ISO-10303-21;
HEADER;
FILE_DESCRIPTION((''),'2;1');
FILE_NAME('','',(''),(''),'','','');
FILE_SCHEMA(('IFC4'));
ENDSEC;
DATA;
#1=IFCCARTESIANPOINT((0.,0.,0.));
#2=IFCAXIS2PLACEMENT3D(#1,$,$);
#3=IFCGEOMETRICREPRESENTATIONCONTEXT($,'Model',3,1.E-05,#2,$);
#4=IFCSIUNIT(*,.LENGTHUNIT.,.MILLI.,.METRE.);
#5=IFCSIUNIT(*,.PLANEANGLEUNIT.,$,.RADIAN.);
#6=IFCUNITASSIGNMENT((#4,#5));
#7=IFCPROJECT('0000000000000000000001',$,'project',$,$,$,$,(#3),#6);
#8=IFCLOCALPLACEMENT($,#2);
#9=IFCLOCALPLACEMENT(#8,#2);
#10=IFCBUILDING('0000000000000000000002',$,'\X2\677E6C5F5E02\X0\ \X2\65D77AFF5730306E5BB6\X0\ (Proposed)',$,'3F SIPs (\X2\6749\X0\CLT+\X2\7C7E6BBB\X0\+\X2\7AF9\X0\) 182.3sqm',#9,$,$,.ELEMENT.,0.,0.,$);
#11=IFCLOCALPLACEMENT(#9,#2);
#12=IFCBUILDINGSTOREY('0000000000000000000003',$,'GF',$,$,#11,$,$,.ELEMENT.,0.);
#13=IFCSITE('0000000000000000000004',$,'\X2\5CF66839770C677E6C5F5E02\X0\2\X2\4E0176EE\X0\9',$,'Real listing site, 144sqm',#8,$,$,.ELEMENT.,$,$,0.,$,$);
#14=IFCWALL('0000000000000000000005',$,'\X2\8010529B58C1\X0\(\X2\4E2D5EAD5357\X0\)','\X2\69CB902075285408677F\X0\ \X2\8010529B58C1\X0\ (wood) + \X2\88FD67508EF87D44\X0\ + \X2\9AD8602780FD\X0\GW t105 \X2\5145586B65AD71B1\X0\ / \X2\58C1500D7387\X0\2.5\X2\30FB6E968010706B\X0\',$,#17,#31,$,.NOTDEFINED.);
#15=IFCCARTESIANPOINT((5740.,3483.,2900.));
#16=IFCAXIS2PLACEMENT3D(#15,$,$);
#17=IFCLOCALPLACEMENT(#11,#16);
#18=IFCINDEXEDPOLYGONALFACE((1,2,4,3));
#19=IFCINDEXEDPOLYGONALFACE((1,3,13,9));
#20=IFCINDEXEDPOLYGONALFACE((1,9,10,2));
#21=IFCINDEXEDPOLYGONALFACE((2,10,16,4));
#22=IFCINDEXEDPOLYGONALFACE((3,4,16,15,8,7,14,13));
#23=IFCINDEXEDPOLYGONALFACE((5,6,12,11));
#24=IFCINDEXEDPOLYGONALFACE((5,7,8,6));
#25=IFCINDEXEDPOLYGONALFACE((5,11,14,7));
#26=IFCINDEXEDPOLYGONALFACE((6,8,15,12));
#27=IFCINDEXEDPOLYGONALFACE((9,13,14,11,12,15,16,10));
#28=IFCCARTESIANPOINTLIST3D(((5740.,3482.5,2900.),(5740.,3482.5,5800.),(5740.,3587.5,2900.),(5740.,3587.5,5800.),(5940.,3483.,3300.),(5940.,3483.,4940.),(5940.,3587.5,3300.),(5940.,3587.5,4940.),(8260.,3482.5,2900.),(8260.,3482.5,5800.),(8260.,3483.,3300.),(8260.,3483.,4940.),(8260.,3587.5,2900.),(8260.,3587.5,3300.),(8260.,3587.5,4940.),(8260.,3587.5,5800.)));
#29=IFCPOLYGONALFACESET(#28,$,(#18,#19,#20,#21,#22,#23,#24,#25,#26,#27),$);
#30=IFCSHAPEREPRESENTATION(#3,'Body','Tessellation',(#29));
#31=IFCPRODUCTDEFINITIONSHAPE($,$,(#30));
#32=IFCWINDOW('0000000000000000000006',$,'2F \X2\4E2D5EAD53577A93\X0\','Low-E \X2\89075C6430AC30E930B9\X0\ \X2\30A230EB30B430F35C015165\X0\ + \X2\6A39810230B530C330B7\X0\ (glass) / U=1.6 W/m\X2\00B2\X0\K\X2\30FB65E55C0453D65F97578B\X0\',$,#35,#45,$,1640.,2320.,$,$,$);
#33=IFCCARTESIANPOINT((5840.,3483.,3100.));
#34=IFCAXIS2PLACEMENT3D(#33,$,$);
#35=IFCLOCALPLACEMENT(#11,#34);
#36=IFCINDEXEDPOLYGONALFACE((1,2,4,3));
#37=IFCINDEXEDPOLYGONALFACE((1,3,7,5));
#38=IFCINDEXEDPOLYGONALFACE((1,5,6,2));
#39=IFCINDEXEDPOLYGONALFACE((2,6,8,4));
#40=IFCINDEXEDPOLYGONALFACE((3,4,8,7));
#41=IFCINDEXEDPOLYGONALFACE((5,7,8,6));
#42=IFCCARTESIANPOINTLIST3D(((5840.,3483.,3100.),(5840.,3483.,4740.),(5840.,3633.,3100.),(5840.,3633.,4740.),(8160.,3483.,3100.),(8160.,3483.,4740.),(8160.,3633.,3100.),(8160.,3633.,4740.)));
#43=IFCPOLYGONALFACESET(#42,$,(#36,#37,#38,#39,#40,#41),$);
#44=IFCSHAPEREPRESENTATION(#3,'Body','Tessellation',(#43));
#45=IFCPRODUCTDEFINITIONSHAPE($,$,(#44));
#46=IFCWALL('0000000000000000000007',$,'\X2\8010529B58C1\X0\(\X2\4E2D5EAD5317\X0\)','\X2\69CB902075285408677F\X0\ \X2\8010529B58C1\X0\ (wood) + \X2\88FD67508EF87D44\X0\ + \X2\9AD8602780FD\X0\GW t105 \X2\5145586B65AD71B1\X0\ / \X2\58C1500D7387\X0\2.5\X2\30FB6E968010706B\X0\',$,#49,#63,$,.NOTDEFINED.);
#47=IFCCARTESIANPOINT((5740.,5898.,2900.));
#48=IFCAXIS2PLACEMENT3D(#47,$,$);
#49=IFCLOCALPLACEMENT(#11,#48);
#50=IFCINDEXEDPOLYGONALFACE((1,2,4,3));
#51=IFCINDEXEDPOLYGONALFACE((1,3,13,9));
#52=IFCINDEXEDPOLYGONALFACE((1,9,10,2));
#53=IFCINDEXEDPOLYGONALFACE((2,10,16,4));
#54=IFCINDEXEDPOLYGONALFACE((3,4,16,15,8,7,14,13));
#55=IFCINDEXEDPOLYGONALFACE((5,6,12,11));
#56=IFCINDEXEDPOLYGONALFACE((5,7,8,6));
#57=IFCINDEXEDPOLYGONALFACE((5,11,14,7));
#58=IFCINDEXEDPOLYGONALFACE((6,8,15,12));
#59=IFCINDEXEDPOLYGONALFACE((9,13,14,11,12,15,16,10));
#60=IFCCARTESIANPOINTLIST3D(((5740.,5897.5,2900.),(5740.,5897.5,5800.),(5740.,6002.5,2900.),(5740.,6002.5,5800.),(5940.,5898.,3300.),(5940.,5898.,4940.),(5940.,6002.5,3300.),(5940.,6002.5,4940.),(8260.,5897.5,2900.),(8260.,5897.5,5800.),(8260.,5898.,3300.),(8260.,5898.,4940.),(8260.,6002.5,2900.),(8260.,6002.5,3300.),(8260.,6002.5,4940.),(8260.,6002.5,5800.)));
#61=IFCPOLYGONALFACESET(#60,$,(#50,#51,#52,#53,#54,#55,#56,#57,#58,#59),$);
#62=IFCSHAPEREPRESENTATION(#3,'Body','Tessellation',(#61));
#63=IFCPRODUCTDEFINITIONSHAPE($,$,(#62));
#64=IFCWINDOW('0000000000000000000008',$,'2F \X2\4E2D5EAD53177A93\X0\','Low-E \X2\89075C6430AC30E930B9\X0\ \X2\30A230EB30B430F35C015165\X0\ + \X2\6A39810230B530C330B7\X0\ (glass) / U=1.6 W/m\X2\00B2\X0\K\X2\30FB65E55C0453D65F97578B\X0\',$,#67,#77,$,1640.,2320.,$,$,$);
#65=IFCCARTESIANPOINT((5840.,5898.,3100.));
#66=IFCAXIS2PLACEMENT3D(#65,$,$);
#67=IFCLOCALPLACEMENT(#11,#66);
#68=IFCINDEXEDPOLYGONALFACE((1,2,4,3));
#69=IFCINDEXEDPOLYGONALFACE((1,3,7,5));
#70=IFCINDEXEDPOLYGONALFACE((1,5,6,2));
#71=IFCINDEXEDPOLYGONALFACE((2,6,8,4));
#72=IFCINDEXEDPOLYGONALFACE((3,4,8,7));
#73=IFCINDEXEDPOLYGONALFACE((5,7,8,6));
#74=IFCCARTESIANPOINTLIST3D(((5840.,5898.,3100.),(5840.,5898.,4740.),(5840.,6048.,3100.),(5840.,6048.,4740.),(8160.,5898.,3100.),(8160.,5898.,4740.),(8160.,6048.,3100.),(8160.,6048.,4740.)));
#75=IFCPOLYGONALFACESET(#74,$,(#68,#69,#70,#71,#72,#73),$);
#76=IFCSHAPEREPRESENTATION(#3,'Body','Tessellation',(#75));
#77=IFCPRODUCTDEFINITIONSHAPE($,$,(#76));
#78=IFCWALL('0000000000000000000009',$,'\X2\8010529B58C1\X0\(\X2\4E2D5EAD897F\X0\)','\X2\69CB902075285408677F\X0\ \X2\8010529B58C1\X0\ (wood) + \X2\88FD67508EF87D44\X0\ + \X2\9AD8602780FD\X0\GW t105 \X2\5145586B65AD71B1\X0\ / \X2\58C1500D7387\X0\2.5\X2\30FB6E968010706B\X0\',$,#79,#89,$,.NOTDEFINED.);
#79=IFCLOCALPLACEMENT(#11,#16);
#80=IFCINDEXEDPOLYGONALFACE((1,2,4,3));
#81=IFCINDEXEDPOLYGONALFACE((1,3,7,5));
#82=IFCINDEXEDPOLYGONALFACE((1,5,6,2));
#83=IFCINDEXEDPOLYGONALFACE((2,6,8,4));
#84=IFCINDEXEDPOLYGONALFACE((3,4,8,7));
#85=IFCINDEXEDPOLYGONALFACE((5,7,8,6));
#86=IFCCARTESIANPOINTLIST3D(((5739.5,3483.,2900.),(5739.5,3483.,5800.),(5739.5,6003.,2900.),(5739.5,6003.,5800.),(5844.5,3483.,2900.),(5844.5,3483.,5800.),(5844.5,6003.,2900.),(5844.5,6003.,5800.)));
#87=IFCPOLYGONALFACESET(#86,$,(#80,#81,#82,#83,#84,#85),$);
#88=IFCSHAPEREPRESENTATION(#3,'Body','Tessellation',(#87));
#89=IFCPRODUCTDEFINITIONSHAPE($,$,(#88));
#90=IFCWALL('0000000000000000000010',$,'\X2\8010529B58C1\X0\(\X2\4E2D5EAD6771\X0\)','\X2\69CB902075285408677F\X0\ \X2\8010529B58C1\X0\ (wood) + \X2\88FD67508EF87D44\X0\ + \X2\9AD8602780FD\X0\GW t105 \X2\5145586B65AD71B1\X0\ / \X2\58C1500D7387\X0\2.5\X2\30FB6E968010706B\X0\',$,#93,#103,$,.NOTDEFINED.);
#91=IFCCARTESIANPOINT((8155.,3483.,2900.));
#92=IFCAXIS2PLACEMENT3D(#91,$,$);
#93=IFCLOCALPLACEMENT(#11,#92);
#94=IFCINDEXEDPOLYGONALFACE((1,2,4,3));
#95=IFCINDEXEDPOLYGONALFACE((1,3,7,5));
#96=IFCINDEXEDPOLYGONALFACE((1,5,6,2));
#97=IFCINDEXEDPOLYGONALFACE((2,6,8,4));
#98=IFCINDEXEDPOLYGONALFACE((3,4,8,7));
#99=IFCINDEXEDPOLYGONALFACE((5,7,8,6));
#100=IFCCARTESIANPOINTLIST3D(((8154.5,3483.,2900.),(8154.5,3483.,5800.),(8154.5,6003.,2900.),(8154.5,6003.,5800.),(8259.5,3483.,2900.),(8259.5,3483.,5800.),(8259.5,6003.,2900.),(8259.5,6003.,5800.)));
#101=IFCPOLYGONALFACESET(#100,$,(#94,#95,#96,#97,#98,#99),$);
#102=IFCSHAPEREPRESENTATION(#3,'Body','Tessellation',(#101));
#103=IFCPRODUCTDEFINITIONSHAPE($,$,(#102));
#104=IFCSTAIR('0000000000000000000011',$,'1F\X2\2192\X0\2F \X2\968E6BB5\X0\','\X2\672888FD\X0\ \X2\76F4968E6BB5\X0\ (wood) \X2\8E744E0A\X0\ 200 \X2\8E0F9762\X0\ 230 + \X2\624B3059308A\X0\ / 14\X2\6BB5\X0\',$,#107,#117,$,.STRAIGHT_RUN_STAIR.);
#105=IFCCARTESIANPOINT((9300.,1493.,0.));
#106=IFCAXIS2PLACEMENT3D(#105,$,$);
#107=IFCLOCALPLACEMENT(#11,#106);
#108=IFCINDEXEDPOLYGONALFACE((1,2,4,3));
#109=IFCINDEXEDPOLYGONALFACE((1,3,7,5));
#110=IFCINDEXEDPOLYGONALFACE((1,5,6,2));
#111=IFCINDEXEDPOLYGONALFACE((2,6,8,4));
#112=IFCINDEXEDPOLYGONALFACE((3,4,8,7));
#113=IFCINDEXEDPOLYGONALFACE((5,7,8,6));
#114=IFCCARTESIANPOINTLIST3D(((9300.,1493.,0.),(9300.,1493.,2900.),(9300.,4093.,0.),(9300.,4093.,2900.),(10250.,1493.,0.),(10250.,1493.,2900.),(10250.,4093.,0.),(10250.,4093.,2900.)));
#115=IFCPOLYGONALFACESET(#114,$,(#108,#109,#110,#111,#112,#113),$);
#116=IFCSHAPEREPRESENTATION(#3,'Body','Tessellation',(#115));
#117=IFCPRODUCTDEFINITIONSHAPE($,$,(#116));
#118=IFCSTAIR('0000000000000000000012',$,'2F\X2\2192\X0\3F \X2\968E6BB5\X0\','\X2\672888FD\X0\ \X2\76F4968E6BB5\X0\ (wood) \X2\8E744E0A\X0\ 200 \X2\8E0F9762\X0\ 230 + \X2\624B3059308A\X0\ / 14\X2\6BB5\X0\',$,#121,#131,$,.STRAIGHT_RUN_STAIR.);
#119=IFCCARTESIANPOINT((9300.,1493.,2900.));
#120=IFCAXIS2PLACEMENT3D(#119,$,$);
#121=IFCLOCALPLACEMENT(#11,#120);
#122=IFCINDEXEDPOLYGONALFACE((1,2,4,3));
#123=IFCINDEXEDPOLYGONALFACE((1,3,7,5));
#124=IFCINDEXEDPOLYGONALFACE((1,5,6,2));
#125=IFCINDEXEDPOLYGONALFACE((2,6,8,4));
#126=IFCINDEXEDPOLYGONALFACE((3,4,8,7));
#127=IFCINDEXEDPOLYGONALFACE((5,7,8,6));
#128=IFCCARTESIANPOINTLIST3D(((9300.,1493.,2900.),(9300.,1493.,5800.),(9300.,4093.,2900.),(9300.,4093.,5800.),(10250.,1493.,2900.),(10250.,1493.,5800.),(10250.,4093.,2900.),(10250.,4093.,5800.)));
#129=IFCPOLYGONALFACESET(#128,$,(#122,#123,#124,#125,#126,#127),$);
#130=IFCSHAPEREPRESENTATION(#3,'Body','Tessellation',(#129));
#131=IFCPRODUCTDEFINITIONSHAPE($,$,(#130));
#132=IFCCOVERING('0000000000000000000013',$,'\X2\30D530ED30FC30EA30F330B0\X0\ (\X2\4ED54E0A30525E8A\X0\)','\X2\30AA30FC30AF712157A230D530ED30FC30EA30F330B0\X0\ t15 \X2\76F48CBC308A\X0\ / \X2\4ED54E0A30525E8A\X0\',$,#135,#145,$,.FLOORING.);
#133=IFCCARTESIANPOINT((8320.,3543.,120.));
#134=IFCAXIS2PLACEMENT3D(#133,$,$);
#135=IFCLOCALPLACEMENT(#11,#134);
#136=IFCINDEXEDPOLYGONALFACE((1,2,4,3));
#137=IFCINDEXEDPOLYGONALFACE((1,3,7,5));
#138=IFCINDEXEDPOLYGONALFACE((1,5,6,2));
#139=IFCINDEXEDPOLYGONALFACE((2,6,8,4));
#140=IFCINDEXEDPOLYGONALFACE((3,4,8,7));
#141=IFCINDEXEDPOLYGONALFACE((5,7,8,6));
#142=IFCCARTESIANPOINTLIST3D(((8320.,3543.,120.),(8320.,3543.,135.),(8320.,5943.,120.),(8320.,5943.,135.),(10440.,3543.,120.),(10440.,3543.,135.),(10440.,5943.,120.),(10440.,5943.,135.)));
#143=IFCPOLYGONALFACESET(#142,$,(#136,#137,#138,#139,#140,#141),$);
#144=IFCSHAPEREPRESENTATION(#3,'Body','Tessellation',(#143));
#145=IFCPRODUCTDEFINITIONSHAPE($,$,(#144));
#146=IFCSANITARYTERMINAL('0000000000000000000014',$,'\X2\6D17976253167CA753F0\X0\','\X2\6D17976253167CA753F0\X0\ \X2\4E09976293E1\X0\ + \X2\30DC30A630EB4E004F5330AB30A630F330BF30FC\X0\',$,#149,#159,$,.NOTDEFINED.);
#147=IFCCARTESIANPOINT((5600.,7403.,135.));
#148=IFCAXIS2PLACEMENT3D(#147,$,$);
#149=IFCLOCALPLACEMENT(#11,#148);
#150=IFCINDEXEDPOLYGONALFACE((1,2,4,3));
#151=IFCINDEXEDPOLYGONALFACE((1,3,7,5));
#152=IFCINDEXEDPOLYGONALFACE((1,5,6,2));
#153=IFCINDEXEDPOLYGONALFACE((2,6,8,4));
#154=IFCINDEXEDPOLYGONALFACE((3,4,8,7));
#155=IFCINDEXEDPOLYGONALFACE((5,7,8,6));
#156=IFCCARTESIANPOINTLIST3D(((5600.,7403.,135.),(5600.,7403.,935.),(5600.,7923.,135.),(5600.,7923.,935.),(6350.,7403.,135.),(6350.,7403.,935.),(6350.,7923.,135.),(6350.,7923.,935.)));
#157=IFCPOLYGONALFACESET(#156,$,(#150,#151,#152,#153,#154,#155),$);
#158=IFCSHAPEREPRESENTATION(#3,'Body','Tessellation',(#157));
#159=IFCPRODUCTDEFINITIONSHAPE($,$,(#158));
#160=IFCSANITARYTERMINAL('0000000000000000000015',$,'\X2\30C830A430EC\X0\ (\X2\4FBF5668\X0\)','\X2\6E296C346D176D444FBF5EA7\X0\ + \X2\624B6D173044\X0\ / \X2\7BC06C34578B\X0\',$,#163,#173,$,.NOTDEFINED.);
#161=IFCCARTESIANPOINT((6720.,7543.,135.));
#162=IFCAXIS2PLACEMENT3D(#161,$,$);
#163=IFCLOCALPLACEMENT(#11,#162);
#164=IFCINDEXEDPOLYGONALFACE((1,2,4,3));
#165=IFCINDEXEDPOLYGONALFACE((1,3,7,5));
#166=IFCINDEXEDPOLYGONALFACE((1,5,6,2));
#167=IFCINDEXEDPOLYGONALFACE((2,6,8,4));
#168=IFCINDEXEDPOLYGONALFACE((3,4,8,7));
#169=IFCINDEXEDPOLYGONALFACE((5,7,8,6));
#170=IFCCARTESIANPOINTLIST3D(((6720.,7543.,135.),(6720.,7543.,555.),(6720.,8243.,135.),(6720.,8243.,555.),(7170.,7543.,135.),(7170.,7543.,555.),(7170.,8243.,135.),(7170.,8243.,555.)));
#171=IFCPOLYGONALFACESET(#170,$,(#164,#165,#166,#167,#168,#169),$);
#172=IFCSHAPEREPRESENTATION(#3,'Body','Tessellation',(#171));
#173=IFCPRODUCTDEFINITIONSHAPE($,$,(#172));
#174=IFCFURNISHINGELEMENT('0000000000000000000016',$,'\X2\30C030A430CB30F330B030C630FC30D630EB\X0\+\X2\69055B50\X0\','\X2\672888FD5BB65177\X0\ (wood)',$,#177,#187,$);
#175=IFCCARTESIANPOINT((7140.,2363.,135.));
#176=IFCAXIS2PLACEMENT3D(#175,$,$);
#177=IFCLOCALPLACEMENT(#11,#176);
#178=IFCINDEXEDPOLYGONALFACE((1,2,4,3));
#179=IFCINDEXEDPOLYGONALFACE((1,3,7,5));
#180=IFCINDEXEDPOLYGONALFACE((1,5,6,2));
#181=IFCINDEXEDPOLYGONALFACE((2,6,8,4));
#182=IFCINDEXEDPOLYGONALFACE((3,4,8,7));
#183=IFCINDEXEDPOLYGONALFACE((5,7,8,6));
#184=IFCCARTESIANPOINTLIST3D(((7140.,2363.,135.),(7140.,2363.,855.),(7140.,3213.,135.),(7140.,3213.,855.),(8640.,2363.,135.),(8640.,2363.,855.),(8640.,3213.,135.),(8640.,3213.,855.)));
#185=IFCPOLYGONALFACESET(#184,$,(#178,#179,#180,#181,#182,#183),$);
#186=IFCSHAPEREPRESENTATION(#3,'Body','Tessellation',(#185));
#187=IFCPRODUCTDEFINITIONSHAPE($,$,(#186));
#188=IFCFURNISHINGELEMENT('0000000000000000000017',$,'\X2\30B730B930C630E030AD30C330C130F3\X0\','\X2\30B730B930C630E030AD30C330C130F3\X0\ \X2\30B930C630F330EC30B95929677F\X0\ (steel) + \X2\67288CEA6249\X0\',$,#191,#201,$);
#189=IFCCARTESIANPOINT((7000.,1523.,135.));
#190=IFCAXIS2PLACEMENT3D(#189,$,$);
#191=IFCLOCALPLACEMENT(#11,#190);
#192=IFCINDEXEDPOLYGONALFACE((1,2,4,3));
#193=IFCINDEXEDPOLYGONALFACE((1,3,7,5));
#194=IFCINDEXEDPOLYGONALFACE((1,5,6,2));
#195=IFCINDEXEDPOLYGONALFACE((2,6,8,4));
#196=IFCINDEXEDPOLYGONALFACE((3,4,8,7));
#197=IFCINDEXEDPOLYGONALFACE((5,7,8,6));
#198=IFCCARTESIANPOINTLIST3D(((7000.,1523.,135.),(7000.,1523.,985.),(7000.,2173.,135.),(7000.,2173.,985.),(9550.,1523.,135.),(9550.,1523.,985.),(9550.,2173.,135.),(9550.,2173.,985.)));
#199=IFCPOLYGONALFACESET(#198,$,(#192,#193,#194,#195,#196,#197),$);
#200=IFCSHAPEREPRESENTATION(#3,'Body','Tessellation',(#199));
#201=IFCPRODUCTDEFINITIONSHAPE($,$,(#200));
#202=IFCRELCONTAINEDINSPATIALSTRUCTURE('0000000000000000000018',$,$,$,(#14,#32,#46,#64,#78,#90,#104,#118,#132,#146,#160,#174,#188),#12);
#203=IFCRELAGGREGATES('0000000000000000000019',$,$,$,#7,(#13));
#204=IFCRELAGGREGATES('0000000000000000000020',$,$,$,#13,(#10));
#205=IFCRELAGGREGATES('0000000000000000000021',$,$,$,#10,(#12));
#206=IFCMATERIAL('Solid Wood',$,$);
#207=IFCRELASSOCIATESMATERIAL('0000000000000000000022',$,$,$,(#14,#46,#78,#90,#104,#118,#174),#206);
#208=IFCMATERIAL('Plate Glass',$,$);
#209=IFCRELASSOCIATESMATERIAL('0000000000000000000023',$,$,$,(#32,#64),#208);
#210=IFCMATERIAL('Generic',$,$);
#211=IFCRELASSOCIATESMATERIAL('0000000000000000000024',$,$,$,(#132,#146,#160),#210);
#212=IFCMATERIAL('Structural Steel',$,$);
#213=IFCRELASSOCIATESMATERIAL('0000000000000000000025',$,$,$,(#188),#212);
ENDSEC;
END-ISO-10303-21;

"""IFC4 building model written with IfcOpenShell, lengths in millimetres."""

from ifc_helpers import new_model, si_unit, frame, frame_2d, origin, place, context, project, spatial, rectangle, extrude, material, element, fill, save


model = new_model("IFC4")

# Units and contexts
model_context = context("Model", 3, precision=1e-05, world=origin())
ifc_project = project(units=[si_unit("LENGTHUNIT", "METRE", prefix="MILLI"), si_unit("PLANEANGLEUNIT", "RADIAN")], contexts=[model_context])

# Site, building, storey
site_placement = place(None, origin())
site = spatial("IfcSite", under=ifc_project, at=site_placement, Name="島根県松江市2丁目9", ObjectType="Real listing site, 144sqm", CompositionType="ELEMENT", RefElevation=0.0)
building_placement = place(site_placement, origin())
building = spatial("IfcBuilding", under=site, at=building_placement, Name="松江市 旗竿地の家 (Proposed)", ObjectType="3F SIPs (杉CLT+籾殻+竹) 182.3sqm", CompositionType="ELEMENT", ElevationOfRefHeight=0.0, ElevationOfTerrain=0.0)
storey_placement = place(building_placement, origin())
storey = spatial("IfcBuildingStorey", under=building, at=storey_placement, Name="GF", CompositionType="ELEMENT", Elevation=0.0)

# Shared definitions
ifc_material_1 = material(Name="Solid Wood")

# Shared definitions
ifc_material_2 = material(Name="Plate Glass")

# Walls, openings, windows
wall_1_placement = place(storey_placement, frame((5740.0, 3483.0, 2900.0)))
wall_1 = element("IfcWall", 1, at=wall_1_placement, inside=storey, material=ifc_material_1, Name="耐力壁(中庭南)", Description="構造用合板 耐力壁 (wood) + 製材軸組 + 高性能GW t105 充填断熱 / 壁倍率2.5・準耐火", PredefinedType="NOTDEFINED", context=model_context, shape_type="SweptSolid", body=[
    extrude(rectangle(XDim=2520.0, YDim=105.0, at=frame_2d((1260.0, 52.0))), frame((5740.0, 3483.0, 2900.0)), (0.0, 0.0, 1.0), 2900.0),
])
opening_1_placement = place(storey_placement, frame((5840.0, 3483.0, 3100.0)))
opening_1 = element("IfcOpeningElement", 2, at=opening_1_placement, cuts=wall_1, PredefinedType="NOTDEFINED", context=model_context, shape_type="SweptSolid", body=[
    extrude(rectangle(XDim=2320.0, YDim=150.0, at=frame_2d((1160.0, 75.0))), frame((5840.0, 3483.0, 3100.0)), (0.0, 0.0, 1.0), 1640.0),
])
window_1_placement = place(storey_placement, frame((5840.0, 3483.0, 3100.0)))
window_1 = element("IfcWindow", 3, at=window_1_placement, inside=storey, material=ifc_material_2, Name="2F 中庭南窓", Description="Low-E 複層ガラス アルゴン封入 + 樹脂サッシ (glass) / U=1.6 W/m²K・日射取得型", OverallHeight=1640.0, OverallWidth=2320.0, context=model_context, shape_type="SweptSolid", body=[
    extrude(rectangle(XDim=2320.0, YDim=150.0, at=frame_2d((1160.0, 75.0))), frame((5840.0, 3483.0, 3100.0)), (0.0, 0.0, 1.0), 1640.0),
])
fill(opening_1, window_1)
wall_2_placement = place(storey_placement, frame((5740.0, 5898.0, 2900.0)))
wall_2 = element("IfcWall", 4, at=wall_2_placement, inside=storey, material=ifc_material_1, Name="耐力壁(中庭北)", Description="構造用合板 耐力壁 (wood) + 製材軸組 + 高性能GW t105 充填断熱 / 壁倍率2.5・準耐火", PredefinedType="NOTDEFINED", context=model_context, shape_type="SweptSolid", body=[
    extrude(rectangle(XDim=2520.0, YDim=105.0, at=frame_2d((1260.0, 52.0))), frame((5740.0, 5898.0, 2900.0)), (0.0, 0.0, 1.0), 2900.0),
])
opening_2_placement = place(storey_placement, frame((5840.0, 5898.0, 3100.0)))
opening_2 = element("IfcOpeningElement", 5, at=opening_2_placement, cuts=wall_2, PredefinedType="NOTDEFINED", context=model_context, shape_type="SweptSolid", body=[
    extrude(rectangle(XDim=2320.0, YDim=150.0, at=frame_2d((1160.0, 75.0))), frame((5840.0, 5898.0, 3100.0)), (0.0, 0.0, 1.0), 1640.0),
])
window_2_placement = place(storey_placement, frame((5840.0, 5898.0, 3100.0)))
window_2 = element("IfcWindow", 6, at=window_2_placement, inside=storey, material=ifc_material_2, Name="2F 中庭北窓", Description="Low-E 複層ガラス アルゴン封入 + 樹脂サッシ (glass) / U=1.6 W/m²K・日射取得型", OverallHeight=1640.0, OverallWidth=2320.0, context=model_context, shape_type="SweptSolid", body=[
    extrude(rectangle(XDim=2320.0, YDim=150.0, at=frame_2d((1160.0, 75.0))), frame((5840.0, 5898.0, 3100.0)), (0.0, 0.0, 1.0), 1640.0),
])
fill(opening_2, window_2)

# Walls
wall_3_placement = place(storey_placement, frame((5740.0, 3483.0, 2900.0)))
element("IfcWall", 7, at=wall_3_placement, inside=storey, material=ifc_material_1, Name="耐力壁(中庭西)", Description="構造用合板 耐力壁 (wood) + 製材軸組 + 高性能GW t105 充填断熱 / 壁倍率2.5・準耐火", PredefinedType="NOTDEFINED", context=model_context, shape_type="SweptSolid", body=[
    extrude(rectangle(XDim=105.0, YDim=2520.0, at=frame_2d((52.0, 1260.0))), frame((5740.0, 3483.0, 2900.0)), (0.0, 0.0, 1.0), 2900.0),
])
wall_4_placement = place(storey_placement, frame((8155.0, 3483.0, 2900.0)))
element("IfcWall", 8, at=wall_4_placement, inside=storey, material=ifc_material_1, Name="耐力壁(中庭東)", Description="構造用合板 耐力壁 (wood) + 製材軸組 + 高性能GW t105 充填断熱 / 壁倍率2.5・準耐火", PredefinedType="NOTDEFINED", context=model_context, shape_type="SweptSolid", body=[
    extrude(rectangle(XDim=105.0, YDim=2520.0, at=frame_2d((52.0, 1260.0))), frame((8155.0, 3483.0, 2900.0)), (0.0, 0.0, 1.0), 2900.0),
])

# Stairs
stair_1_placement = place(storey_placement, frame((9300.0, 1493.0, 0.0)))
element("IfcStair", 9, at=stair_1_placement, inside=storey, material=ifc_material_1, Name="1F→2F 階段", Description="木製 直階段 (wood) 蹴上 200 踏面 230 + 手すり / 14段", PredefinedType="STRAIGHT_RUN_STAIR", context=model_context, shape_type="SweptSolid", body=[
    extrude(rectangle(XDim=950.0, YDim=2600.0, at=frame_2d((475.0, 1300.0))), frame((9300.0, 1493.0, 0.0)), (0.0, 0.0, 1.0), 2900.0),
])
stair_2_placement = place(storey_placement, frame((9300.0, 1493.0, 2900.0)))
element("IfcStair", 10, at=stair_2_placement, inside=storey, material=ifc_material_1, Name="2F→3F 階段", Description="木製 直階段 (wood) 蹴上 200 踏面 230 + 手すり / 14段", PredefinedType="STRAIGHT_RUN_STAIR", context=model_context, shape_type="SweptSolid", body=[
    extrude(rectangle(XDim=950.0, YDim=2600.0, at=frame_2d((475.0, 1300.0))), frame((9300.0, 1493.0, 2900.0)), (0.0, 0.0, 1.0), 2900.0),
])

# Covering
ifc_material_3 = material(Name="Generic")
covering_placement = place(storey_placement, frame((8320.0, 3543.0, 120.0)))
element("IfcCovering", 11, at=covering_placement, inside=storey, material=ifc_material_3, Name="フローリング (仕上げ床)", Description="オーク無垢フローリング t15 直貼り / 仕上げ床", PredefinedType="FLOORING", context=model_context, shape_type="SweptSolid", body=[
    extrude(rectangle(XDim=2120.0, YDim=2400.0, at=frame_2d((1060.0, 1200.0))), frame((8320.0, 3543.0, 120.0)), (0.0, 0.0, 1.0), 15.0),
])

# Sanitary terminals
sanitary_terminal_1_placement = place(storey_placement, frame((5600.0, 7403.0, 135.0)))
element("IfcSanitaryTerminal", 12, at=sanitary_terminal_1_placement, inside=storey, material=ifc_material_3, Name="洗面化粧台", Description="洗面化粧台 三面鏡 + ボウル一体カウンター", PredefinedType="NOTDEFINED", context=model_context, shape_type="SweptSolid", body=[
    extrude(rectangle(XDim=750.0, YDim=520.0, at=frame_2d((375.0, 260.0))), frame((5600.0, 7403.0, 135.0)), (0.0, 0.0, 1.0), 800.0),
])
sanitary_terminal_2_placement = place(storey_placement, frame((6720.0, 7543.0, 135.0)))
element("IfcSanitaryTerminal", 13, at=sanitary_terminal_2_placement, inside=storey, material=ifc_material_3, Name="トイレ (便器)", Description="温水洗浄便座 + 手洗い / 節水型", PredefinedType="NOTDEFINED", context=model_context, shape_type="SweptSolid", body=[
    extrude(rectangle(XDim=450.0, YDim=700.0, at=frame_2d((225.0, 350.0))), frame((6720.0, 7543.0, 135.0)), (0.0, 0.0, 1.0), 420.0),
])

# Furnishing elements
furnishing_1_placement = place(storey_placement, frame((7140.0, 2363.0, 135.0)))
element("IfcFurnishingElement", 14, at=furnishing_1_placement, inside=storey, material=ifc_material_1, Name="ダイニングテーブル+椅子", Description="木製家具 (wood)", context=model_context, shape_type="SweptSolid", body=[
    extrude(rectangle(XDim=1500.0, YDim=850.0, at=frame_2d((750.0, 425.0))), frame((7140.0, 2363.0, 135.0)), (0.0, 0.0, 1.0), 720.0),
])
ifc_material_4 = material(Name="Structural Steel")
furnishing_2_placement = place(storey_placement, frame((7000.0, 1523.0, 135.0)))
element("IfcFurnishingElement", 15, at=furnishing_2_placement, inside=storey, material=ifc_material_4, Name="システムキッチン", Description="システムキッチン ステンレス天板 (steel) + 木質扉", context=model_context, shape_type="SweptSolid", body=[
    extrude(rectangle(XDim=2550.0, YDim=650.0, at=frame_2d((1275.0, 325.0))), frame((7000.0, 1523.0, 135.0)), (0.0, 0.0, 1.0), 850.0),
])

save(model, "model.ifc")
